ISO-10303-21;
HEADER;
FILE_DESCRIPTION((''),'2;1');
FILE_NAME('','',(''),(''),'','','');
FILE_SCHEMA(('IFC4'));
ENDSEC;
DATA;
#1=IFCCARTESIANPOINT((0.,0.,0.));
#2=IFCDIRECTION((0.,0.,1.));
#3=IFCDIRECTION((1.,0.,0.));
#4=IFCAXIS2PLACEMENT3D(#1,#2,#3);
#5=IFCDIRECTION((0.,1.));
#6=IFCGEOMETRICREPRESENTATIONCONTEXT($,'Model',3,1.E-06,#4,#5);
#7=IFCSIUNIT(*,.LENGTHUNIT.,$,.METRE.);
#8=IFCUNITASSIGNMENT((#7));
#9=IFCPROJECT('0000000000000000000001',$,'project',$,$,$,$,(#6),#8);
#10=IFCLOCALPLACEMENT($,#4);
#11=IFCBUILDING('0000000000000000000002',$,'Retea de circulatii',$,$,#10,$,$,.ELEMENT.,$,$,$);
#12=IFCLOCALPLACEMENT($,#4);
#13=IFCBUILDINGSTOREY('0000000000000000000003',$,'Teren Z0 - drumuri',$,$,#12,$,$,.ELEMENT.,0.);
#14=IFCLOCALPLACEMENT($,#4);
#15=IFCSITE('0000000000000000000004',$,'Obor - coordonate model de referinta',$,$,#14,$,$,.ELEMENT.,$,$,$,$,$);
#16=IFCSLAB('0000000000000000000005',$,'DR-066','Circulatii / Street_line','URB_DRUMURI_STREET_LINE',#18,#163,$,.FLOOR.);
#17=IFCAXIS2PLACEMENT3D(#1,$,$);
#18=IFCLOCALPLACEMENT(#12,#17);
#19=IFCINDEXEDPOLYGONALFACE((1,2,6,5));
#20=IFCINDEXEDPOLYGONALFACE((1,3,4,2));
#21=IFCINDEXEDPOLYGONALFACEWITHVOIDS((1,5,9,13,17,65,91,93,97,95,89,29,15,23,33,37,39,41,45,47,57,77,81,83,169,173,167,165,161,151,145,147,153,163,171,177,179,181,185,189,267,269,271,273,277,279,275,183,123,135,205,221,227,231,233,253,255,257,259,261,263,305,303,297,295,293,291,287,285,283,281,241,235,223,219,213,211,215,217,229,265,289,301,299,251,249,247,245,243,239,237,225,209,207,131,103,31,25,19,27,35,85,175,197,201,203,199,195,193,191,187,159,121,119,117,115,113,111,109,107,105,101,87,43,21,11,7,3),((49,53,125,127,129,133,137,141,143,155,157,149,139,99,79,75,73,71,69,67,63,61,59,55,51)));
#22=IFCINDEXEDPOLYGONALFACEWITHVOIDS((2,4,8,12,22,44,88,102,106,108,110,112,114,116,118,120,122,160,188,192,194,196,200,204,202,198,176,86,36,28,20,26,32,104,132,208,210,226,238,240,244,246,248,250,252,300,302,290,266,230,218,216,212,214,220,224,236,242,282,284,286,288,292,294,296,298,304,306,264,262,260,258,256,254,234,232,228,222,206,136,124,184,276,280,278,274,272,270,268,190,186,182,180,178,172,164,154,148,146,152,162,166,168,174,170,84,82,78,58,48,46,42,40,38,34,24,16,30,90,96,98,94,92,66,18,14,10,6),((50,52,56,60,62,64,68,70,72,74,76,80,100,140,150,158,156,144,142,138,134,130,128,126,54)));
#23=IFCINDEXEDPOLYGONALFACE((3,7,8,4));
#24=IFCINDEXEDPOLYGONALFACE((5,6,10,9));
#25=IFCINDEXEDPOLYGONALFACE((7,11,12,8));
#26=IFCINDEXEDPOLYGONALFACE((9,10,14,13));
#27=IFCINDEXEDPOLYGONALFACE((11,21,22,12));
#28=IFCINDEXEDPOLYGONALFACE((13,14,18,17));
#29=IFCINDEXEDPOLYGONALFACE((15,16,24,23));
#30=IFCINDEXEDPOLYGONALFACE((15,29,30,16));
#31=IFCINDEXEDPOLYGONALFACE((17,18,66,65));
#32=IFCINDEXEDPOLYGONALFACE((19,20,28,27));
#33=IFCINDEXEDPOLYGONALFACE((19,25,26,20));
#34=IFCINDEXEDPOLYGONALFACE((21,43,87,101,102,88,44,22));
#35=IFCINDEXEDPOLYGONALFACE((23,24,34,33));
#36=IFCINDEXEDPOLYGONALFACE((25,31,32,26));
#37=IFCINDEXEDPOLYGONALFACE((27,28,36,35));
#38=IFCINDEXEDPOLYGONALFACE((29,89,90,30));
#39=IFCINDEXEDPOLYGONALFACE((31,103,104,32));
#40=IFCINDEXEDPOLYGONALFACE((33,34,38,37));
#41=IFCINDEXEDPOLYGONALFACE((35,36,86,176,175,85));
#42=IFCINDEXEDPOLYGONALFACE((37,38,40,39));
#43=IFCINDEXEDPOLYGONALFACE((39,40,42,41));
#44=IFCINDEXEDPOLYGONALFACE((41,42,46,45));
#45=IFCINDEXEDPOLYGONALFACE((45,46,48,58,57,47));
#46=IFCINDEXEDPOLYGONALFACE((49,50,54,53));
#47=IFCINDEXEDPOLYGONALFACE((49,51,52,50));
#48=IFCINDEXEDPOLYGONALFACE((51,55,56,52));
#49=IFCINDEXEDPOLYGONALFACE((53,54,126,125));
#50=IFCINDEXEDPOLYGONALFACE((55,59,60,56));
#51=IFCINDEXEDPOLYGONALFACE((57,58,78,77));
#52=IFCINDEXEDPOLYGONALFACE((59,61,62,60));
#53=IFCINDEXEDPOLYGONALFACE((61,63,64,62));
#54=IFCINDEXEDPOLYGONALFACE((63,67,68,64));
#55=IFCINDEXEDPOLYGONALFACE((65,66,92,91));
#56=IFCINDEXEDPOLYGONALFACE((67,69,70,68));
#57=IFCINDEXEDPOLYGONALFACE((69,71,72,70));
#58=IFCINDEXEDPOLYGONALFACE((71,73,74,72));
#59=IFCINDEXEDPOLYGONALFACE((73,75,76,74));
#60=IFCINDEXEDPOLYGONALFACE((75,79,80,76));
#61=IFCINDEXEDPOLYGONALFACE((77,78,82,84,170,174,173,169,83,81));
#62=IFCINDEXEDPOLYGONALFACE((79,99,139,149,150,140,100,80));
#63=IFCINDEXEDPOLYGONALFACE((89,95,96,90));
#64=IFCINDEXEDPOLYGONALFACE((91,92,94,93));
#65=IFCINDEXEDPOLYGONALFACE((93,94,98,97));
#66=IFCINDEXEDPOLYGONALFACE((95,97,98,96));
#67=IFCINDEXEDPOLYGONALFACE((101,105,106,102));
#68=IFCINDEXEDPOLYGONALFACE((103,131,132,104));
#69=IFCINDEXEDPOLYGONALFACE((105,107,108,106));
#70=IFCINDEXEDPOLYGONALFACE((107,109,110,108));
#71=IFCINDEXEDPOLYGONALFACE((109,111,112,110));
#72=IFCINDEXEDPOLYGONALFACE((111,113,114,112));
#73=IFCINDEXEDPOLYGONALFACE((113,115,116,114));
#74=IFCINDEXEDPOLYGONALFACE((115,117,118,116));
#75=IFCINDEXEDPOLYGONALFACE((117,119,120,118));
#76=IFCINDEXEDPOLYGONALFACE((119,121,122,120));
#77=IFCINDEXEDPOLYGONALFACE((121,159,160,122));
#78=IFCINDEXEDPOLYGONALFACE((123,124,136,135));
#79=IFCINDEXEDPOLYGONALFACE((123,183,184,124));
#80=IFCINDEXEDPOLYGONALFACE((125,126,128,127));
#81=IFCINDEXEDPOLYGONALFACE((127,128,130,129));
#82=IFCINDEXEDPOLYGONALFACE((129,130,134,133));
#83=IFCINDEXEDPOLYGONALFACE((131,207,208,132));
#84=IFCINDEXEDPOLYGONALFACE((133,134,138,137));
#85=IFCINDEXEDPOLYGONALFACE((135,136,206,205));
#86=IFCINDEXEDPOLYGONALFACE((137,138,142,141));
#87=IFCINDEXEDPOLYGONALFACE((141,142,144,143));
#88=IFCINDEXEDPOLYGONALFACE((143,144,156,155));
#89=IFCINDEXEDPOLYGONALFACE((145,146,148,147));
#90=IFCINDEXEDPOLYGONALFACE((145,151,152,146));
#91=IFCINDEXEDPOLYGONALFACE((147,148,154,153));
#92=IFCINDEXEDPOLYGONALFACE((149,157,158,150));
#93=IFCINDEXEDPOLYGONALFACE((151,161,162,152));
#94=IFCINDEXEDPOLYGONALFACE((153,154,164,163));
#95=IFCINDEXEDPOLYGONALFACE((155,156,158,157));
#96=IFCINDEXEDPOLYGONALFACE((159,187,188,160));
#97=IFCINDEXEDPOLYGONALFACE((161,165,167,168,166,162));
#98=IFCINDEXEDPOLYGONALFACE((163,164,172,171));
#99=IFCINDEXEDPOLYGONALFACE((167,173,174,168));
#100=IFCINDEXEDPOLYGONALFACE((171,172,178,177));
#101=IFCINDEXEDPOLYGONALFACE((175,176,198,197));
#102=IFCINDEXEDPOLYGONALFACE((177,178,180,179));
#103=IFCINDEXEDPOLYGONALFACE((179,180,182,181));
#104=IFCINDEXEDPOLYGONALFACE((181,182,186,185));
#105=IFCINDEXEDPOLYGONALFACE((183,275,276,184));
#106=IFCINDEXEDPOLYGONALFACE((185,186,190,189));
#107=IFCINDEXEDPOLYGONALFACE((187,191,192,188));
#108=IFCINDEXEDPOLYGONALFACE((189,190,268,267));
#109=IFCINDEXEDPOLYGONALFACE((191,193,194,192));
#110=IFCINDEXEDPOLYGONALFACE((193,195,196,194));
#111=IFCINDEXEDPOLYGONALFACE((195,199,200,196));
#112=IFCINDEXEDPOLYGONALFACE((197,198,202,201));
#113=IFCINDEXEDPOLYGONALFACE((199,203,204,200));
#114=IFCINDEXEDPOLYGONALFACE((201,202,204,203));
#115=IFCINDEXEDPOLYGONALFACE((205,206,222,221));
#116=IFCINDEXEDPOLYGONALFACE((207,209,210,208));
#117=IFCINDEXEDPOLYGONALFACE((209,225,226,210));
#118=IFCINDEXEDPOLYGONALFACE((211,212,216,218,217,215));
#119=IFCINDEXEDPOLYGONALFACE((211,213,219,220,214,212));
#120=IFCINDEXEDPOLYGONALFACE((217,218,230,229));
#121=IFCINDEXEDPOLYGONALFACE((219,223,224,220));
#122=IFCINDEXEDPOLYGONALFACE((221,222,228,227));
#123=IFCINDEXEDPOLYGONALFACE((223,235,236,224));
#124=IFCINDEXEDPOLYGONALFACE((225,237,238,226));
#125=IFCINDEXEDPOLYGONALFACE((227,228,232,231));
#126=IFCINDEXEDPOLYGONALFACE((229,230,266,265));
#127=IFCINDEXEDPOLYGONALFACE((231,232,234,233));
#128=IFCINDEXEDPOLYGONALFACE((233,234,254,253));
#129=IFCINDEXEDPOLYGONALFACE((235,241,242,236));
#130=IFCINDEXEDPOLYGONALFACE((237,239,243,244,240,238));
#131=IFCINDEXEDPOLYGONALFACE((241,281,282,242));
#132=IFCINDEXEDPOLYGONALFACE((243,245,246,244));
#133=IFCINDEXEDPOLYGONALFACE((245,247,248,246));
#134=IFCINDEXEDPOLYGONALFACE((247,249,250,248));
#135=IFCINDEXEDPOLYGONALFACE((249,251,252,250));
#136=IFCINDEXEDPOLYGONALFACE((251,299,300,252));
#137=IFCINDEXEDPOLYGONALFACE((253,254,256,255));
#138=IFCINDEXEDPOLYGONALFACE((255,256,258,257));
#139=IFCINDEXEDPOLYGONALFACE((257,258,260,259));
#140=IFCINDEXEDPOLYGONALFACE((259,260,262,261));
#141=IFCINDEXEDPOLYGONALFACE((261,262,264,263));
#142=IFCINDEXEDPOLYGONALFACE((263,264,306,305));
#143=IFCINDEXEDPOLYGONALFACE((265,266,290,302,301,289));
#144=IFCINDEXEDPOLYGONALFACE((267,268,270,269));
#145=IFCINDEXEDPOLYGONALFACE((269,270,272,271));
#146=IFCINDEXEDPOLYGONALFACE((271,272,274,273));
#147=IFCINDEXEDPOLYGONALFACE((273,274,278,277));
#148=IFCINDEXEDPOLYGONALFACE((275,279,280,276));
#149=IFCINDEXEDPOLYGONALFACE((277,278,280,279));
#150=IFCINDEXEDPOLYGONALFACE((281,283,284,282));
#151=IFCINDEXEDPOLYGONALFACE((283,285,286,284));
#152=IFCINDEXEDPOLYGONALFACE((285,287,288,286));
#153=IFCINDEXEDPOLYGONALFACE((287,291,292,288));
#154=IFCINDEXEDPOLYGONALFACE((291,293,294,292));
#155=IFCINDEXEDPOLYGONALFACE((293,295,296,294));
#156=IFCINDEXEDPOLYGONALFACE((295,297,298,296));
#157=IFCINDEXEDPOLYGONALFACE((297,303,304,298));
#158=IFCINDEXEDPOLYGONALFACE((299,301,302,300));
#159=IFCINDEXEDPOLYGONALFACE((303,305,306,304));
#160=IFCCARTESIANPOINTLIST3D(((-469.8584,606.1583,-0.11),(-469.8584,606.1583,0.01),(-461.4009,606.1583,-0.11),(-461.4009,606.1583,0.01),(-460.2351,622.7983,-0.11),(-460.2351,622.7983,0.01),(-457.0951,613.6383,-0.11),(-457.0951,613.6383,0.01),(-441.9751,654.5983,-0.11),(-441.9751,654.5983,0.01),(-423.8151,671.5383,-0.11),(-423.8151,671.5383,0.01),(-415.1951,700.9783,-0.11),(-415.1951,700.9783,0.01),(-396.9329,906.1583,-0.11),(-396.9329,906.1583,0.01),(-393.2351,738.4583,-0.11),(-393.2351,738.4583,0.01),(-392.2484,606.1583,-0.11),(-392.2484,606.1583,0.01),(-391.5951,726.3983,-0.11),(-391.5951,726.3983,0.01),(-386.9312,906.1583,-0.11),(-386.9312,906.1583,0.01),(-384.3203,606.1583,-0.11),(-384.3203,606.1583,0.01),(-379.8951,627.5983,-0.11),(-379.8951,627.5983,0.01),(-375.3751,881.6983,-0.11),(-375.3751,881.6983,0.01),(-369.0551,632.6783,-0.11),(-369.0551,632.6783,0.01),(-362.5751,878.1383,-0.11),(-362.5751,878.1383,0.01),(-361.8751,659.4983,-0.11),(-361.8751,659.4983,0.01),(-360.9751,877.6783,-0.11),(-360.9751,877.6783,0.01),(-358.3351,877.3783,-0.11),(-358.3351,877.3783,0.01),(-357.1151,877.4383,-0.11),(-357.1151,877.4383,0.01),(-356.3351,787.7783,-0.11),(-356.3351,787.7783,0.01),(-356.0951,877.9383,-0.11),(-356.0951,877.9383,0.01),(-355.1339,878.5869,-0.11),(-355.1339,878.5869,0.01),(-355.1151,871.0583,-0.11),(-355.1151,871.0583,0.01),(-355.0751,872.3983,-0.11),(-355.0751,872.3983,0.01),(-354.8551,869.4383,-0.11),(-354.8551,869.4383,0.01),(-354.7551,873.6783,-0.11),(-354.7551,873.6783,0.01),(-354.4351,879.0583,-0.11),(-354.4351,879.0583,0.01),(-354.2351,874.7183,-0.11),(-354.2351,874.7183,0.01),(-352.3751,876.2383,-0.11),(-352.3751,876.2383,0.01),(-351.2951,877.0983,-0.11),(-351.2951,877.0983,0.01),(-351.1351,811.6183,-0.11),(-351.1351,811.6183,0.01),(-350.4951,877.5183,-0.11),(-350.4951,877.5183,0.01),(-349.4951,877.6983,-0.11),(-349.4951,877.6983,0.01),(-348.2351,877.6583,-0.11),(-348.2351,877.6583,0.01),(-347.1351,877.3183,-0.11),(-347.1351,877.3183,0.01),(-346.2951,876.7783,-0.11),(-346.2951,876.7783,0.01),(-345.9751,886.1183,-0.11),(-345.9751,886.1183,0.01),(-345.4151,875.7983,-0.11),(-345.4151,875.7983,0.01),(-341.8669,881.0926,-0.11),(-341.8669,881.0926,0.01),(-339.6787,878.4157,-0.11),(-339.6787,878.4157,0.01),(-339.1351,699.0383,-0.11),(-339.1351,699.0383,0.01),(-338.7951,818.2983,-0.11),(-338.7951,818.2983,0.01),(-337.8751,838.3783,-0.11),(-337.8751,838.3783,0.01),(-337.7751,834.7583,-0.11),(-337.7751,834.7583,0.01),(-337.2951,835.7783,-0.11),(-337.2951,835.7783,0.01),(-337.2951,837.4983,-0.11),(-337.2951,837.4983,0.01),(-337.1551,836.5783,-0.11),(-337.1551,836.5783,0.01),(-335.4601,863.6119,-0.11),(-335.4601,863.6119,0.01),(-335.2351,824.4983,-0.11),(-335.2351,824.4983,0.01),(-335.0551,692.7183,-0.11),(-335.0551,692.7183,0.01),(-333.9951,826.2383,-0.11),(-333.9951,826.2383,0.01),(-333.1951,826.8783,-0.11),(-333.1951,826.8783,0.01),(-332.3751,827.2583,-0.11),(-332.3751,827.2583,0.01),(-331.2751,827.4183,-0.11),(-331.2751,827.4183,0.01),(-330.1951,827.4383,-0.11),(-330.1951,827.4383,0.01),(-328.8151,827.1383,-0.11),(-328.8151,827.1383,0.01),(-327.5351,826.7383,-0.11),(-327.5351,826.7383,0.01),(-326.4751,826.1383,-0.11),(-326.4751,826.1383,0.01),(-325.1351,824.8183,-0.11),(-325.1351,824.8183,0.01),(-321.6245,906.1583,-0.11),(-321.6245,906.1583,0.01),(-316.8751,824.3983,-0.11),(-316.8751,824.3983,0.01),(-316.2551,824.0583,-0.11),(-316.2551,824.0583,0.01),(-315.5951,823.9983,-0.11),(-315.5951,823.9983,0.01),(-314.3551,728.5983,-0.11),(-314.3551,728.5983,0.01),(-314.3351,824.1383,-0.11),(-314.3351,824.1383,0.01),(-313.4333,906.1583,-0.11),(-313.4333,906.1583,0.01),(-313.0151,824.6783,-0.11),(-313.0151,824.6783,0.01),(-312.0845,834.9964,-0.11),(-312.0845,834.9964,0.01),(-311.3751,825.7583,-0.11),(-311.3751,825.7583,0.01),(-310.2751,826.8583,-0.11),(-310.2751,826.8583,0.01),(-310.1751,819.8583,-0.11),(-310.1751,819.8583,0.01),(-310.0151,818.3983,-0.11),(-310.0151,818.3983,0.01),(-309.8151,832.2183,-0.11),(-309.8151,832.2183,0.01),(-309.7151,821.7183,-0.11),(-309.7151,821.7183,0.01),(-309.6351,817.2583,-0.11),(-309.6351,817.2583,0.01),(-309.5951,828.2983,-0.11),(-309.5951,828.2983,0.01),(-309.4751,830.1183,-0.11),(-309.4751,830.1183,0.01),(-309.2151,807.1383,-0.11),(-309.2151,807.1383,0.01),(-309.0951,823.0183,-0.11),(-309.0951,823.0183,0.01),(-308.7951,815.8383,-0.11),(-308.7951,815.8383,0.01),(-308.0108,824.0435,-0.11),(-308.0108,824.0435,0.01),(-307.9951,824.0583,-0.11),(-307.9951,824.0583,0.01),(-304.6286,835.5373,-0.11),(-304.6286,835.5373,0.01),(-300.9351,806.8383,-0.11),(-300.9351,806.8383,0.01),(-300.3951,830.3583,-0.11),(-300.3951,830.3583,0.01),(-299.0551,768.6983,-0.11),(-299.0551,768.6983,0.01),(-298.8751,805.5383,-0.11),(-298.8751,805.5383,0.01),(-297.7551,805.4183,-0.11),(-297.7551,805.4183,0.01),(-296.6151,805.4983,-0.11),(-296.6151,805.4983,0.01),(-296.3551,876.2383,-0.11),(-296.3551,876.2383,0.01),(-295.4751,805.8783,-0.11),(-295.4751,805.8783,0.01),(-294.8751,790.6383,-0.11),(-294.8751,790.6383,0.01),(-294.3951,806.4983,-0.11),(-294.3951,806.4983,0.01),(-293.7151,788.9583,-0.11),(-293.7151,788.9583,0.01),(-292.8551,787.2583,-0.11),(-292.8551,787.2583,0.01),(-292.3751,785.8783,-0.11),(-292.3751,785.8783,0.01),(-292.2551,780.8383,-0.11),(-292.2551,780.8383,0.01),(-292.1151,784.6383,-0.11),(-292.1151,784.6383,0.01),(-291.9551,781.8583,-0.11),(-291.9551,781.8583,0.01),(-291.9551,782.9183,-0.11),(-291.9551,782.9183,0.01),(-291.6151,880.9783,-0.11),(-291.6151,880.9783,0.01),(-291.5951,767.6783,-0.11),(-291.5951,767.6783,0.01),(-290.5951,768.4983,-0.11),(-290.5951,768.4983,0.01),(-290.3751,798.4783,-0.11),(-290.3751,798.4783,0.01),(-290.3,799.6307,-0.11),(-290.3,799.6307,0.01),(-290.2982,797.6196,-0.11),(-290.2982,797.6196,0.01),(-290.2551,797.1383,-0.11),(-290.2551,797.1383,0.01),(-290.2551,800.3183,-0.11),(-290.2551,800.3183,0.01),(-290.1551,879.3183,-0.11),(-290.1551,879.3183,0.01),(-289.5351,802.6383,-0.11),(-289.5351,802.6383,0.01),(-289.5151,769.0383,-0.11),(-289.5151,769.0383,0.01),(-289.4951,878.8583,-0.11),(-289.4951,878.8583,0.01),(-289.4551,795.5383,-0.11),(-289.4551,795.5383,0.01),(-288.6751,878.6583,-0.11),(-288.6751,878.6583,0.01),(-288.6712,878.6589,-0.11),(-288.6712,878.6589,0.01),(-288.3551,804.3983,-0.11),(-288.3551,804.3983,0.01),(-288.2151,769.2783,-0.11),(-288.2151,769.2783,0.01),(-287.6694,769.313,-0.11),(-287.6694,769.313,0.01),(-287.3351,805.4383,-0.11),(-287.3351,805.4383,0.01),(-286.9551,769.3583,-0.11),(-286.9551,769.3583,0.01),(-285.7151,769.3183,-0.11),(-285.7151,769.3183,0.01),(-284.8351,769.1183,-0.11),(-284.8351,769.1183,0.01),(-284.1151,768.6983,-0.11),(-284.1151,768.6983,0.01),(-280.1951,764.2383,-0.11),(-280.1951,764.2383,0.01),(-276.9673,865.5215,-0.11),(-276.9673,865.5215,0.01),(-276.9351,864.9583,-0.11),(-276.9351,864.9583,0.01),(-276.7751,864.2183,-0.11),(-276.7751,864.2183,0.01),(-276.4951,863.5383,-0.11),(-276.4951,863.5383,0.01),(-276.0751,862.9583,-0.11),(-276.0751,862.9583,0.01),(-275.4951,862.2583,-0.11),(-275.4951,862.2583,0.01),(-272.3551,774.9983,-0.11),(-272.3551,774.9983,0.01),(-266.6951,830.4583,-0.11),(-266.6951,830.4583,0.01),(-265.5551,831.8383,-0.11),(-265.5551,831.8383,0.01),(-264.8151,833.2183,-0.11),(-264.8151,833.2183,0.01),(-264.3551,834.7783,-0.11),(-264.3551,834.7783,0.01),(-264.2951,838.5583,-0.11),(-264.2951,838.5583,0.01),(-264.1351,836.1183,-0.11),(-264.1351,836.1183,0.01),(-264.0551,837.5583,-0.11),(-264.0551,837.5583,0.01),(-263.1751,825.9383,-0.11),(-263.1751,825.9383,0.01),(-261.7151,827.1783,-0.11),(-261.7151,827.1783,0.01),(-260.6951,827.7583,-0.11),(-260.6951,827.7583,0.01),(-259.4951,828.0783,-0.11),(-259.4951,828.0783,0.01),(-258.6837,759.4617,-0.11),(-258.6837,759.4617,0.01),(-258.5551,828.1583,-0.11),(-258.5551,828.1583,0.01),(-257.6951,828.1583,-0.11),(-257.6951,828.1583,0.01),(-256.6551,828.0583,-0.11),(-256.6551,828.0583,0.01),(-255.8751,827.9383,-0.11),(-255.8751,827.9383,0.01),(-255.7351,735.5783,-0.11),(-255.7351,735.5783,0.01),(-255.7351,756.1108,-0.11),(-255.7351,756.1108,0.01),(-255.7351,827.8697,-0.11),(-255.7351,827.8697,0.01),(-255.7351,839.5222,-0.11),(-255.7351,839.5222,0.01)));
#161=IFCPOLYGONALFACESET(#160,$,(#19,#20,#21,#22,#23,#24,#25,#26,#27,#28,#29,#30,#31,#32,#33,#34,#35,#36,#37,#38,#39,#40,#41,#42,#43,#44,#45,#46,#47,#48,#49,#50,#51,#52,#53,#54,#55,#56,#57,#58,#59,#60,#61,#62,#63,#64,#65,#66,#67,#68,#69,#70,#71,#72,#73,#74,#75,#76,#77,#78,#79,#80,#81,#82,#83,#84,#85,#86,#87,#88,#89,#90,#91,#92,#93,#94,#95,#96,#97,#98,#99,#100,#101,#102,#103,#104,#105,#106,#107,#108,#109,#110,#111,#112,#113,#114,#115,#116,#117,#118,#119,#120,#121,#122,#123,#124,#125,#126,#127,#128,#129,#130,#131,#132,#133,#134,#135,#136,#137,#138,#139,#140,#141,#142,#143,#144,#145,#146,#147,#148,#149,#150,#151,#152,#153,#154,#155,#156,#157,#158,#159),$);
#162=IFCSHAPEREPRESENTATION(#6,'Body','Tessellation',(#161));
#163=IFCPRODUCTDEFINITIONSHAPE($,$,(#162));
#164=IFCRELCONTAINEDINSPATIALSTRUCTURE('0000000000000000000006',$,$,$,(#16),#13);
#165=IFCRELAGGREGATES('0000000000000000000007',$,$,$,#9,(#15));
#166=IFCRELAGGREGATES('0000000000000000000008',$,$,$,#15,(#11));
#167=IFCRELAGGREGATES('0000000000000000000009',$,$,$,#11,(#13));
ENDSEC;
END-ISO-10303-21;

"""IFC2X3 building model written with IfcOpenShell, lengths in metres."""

from ifc_helpers import new_model, si_unit, direction, frame, origin_with_axes, place, context, project, spatial, polyline, outline, extrude, element, save


model = new_model("IFC2X3")

# Units and contexts
model_context = context("Model", 3, precision=1e-06, world=origin_with_axes(), true_north=direction((0.0, 1.0)))
ifc_project = project(units=[si_unit("LENGTHUNIT", "METRE")], contexts=[model_context])

# Site, building, storey
site_placement = place(None, origin_with_axes())
site = spatial("IfcSite", under=ifc_project, at=site_placement, Name="Obor - coordonate model de referinta", CompositionType="ELEMENT")
building_placement = place(None, origin_with_axes())
building = spatial("IfcBuilding", under=site, at=building_placement, Name="Retea de circulatii", CompositionType="ELEMENT")
storey_placement = place(None, origin_with_axes())
storey = spatial("IfcBuildingStorey", under=building, at=storey_placement, Name="Teren Z0 - drumuri", CompositionType="ELEMENT", Elevation=0.0)

# Slab
slab_1_placement = place(None, origin_with_axes())
element("IfcSlab", 1, at=slab_1_placement, inside=storey, Name="DR-066", Description="Circulatii / Street_line", ObjectType="URB_DRUMURI_STREET_LINE", PredefinedType="FLOOR", context=model_context, shape_type="SweptSolid", body=[
    extrude(outline(polyline([(-369.0551, 632.6783), (-335.0551, 692.7183), (-314.3551, 728.5983), (-291.5951, 767.6783), (-290.5951, 768.4983), (-289.5151, 769.0383), (-288.2151, 769.2783), (-287.6694, 769.313), (-286.9551, 769.3583), (-285.7151, 769.3183), (-284.8351, 769.1183), (-284.1151, 768.6983), (-280.1951, 764.2383), (-255.7351, 735.5783), (-255.7351, 756.1108), (-258.6837, 759.4617), (-272.3551, 774.9983), (-289.4551, 795.5383), (-290.2551, 797.1383), (-290.2982, 797.6196), (-290.3751, 798.4783), (-290.3, 799.6307), (-290.2551, 800.3183), (-289.5351, 802.6383), (-288.3551, 804.3983), (-287.3351, 805.4383), (-263.1751, 825.9383), (-261.7151, 827.1783), (-260.6951, 827.7583), (-259.4951, 828.0783), (-258.5551, 828.1583), (-257.6951, 828.1583), (-256.6551, 828.0583), (-255.8751, 827.9383), (-255.7351, 827.8697), (-255.7351, 839.5222), (-275.4951, 862.2583), (-276.0751, 862.9583), (-276.4951, 863.5383), (-276.7751, 864.2183), (-276.9351, 864.9583), (-276.9673, 865.5215), (-288.6712, 878.6589), (-288.6751, 878.6583), (-289.4951, 878.8583), (-290.1551, 879.3183), (-291.6151, 880.9783), (-313.4333, 906.1583), (-321.6245, 906.1583), (-296.3551, 876.2383), (-264.2951, 838.5583), (-264.0551, 837.5583), (-264.1351, 836.1183), (-264.3551, 834.7783), (-264.8151, 833.2183), (-265.5551, 831.8383), (-266.6951, 830.4583), (-294.3951, 806.4983), (-295.4751, 805.8783), (-296.6151, 805.4983), (-297.7551, 805.4183), (-298.8751, 805.5383), (-300.9351, 806.8383), (-308.7951, 815.8383), (-309.6351, 817.2583), (-310.0151, 818.3983), (-310.1751, 819.8583), (-309.7151, 821.7183), (-309.0951, 823.0183), (-308.0108, 824.0435), (-307.9951, 824.0583), (-300.3951, 830.3583), (-304.6286, 835.5373), (-339.6787, 878.4157), (-341.8669, 881.0926), (-345.9751, 886.1183), (-354.4351, 879.0583), (-355.1339, 878.5869), (-356.0951, 877.9383), (-357.1151, 877.4383), (-358.3351, 877.3783), (-360.9751, 877.6783), (-362.5751, 878.1383), (-386.9312, 906.1583), (-396.9329, 906.1583), (-375.3751, 881.6983), (-337.8751, 838.3783), (-337.2951, 837.4983), (-337.1551, 836.5783), (-337.2951, 835.7783), (-337.7751, 834.7583), (-351.1351, 811.6183), (-393.2351, 738.4583), (-415.1951, 700.9783), (-441.9751, 654.5983), (-460.2351, 622.7983), (-469.8584, 606.1583), (-461.4009, 606.1583), (-457.0951, 613.6383), (-423.8151, 671.5383), (-391.5951, 726.3983), (-356.3351, 787.7783), (-338.7951, 818.2983), (-335.2351, 824.4983), (-333.9951, 826.2383), (-333.1951, 826.8783), (-332.3751, 827.2583), (-331.2751, 827.4183), (-330.1951, 827.4383), (-328.8151, 827.1383), (-327.5351, 826.7383), (-326.4751, 826.1383), (-325.1351, 824.8183), (-309.2151, 807.1383), (-294.8751, 790.6383), (-293.7151, 788.9583), (-292.8551, 787.2583), (-292.3751, 785.8783), (-292.1151, 784.6383), (-291.9551, 782.9183), (-291.9551, 781.8583), (-292.2551, 780.8383), (-299.0551, 768.6983), (-339.1351, 699.0383), (-361.8751, 659.4983), (-379.8951, 627.5983), (-392.2484, 606.1583), (-384.3203, 606.1583), (-369.0551, 632.6783)]), holes=[polyline([(-309.5951, 828.2983), (-310.2751, 826.8583), (-311.3751, 825.7583), (-313.0151, 824.6783), (-314.3351, 824.1383), (-315.5951, 823.9983), (-316.2551, 824.0583), (-316.8751, 824.3983), (-354.8551, 869.4383), (-355.1151, 871.0583), (-355.0751, 872.3983), (-354.7551, 873.6783), (-354.2351, 874.7183), (-352.3751, 876.2383), (-351.2951, 877.0983), (-350.4951, 877.5183), (-349.4951, 877.6983), (-348.2351, 877.6583), (-347.1351, 877.3183), (-346.2951, 876.7783), (-345.4151, 875.7983), (-335.4601, 863.6119), (-312.0845, 834.9964), (-309.8151, 832.2183), (-309.4751, 830.1183), (-309.5951, 828.2983)])]), frame((0.0, 0.0, -0.11), z_axis=(0.0, 0.0, 1.0), x_axis=(1.0, 0.0, 0.0)), (0.0, 0.0, 1.0), 0.12),
])

save(model, "model.ifc")
